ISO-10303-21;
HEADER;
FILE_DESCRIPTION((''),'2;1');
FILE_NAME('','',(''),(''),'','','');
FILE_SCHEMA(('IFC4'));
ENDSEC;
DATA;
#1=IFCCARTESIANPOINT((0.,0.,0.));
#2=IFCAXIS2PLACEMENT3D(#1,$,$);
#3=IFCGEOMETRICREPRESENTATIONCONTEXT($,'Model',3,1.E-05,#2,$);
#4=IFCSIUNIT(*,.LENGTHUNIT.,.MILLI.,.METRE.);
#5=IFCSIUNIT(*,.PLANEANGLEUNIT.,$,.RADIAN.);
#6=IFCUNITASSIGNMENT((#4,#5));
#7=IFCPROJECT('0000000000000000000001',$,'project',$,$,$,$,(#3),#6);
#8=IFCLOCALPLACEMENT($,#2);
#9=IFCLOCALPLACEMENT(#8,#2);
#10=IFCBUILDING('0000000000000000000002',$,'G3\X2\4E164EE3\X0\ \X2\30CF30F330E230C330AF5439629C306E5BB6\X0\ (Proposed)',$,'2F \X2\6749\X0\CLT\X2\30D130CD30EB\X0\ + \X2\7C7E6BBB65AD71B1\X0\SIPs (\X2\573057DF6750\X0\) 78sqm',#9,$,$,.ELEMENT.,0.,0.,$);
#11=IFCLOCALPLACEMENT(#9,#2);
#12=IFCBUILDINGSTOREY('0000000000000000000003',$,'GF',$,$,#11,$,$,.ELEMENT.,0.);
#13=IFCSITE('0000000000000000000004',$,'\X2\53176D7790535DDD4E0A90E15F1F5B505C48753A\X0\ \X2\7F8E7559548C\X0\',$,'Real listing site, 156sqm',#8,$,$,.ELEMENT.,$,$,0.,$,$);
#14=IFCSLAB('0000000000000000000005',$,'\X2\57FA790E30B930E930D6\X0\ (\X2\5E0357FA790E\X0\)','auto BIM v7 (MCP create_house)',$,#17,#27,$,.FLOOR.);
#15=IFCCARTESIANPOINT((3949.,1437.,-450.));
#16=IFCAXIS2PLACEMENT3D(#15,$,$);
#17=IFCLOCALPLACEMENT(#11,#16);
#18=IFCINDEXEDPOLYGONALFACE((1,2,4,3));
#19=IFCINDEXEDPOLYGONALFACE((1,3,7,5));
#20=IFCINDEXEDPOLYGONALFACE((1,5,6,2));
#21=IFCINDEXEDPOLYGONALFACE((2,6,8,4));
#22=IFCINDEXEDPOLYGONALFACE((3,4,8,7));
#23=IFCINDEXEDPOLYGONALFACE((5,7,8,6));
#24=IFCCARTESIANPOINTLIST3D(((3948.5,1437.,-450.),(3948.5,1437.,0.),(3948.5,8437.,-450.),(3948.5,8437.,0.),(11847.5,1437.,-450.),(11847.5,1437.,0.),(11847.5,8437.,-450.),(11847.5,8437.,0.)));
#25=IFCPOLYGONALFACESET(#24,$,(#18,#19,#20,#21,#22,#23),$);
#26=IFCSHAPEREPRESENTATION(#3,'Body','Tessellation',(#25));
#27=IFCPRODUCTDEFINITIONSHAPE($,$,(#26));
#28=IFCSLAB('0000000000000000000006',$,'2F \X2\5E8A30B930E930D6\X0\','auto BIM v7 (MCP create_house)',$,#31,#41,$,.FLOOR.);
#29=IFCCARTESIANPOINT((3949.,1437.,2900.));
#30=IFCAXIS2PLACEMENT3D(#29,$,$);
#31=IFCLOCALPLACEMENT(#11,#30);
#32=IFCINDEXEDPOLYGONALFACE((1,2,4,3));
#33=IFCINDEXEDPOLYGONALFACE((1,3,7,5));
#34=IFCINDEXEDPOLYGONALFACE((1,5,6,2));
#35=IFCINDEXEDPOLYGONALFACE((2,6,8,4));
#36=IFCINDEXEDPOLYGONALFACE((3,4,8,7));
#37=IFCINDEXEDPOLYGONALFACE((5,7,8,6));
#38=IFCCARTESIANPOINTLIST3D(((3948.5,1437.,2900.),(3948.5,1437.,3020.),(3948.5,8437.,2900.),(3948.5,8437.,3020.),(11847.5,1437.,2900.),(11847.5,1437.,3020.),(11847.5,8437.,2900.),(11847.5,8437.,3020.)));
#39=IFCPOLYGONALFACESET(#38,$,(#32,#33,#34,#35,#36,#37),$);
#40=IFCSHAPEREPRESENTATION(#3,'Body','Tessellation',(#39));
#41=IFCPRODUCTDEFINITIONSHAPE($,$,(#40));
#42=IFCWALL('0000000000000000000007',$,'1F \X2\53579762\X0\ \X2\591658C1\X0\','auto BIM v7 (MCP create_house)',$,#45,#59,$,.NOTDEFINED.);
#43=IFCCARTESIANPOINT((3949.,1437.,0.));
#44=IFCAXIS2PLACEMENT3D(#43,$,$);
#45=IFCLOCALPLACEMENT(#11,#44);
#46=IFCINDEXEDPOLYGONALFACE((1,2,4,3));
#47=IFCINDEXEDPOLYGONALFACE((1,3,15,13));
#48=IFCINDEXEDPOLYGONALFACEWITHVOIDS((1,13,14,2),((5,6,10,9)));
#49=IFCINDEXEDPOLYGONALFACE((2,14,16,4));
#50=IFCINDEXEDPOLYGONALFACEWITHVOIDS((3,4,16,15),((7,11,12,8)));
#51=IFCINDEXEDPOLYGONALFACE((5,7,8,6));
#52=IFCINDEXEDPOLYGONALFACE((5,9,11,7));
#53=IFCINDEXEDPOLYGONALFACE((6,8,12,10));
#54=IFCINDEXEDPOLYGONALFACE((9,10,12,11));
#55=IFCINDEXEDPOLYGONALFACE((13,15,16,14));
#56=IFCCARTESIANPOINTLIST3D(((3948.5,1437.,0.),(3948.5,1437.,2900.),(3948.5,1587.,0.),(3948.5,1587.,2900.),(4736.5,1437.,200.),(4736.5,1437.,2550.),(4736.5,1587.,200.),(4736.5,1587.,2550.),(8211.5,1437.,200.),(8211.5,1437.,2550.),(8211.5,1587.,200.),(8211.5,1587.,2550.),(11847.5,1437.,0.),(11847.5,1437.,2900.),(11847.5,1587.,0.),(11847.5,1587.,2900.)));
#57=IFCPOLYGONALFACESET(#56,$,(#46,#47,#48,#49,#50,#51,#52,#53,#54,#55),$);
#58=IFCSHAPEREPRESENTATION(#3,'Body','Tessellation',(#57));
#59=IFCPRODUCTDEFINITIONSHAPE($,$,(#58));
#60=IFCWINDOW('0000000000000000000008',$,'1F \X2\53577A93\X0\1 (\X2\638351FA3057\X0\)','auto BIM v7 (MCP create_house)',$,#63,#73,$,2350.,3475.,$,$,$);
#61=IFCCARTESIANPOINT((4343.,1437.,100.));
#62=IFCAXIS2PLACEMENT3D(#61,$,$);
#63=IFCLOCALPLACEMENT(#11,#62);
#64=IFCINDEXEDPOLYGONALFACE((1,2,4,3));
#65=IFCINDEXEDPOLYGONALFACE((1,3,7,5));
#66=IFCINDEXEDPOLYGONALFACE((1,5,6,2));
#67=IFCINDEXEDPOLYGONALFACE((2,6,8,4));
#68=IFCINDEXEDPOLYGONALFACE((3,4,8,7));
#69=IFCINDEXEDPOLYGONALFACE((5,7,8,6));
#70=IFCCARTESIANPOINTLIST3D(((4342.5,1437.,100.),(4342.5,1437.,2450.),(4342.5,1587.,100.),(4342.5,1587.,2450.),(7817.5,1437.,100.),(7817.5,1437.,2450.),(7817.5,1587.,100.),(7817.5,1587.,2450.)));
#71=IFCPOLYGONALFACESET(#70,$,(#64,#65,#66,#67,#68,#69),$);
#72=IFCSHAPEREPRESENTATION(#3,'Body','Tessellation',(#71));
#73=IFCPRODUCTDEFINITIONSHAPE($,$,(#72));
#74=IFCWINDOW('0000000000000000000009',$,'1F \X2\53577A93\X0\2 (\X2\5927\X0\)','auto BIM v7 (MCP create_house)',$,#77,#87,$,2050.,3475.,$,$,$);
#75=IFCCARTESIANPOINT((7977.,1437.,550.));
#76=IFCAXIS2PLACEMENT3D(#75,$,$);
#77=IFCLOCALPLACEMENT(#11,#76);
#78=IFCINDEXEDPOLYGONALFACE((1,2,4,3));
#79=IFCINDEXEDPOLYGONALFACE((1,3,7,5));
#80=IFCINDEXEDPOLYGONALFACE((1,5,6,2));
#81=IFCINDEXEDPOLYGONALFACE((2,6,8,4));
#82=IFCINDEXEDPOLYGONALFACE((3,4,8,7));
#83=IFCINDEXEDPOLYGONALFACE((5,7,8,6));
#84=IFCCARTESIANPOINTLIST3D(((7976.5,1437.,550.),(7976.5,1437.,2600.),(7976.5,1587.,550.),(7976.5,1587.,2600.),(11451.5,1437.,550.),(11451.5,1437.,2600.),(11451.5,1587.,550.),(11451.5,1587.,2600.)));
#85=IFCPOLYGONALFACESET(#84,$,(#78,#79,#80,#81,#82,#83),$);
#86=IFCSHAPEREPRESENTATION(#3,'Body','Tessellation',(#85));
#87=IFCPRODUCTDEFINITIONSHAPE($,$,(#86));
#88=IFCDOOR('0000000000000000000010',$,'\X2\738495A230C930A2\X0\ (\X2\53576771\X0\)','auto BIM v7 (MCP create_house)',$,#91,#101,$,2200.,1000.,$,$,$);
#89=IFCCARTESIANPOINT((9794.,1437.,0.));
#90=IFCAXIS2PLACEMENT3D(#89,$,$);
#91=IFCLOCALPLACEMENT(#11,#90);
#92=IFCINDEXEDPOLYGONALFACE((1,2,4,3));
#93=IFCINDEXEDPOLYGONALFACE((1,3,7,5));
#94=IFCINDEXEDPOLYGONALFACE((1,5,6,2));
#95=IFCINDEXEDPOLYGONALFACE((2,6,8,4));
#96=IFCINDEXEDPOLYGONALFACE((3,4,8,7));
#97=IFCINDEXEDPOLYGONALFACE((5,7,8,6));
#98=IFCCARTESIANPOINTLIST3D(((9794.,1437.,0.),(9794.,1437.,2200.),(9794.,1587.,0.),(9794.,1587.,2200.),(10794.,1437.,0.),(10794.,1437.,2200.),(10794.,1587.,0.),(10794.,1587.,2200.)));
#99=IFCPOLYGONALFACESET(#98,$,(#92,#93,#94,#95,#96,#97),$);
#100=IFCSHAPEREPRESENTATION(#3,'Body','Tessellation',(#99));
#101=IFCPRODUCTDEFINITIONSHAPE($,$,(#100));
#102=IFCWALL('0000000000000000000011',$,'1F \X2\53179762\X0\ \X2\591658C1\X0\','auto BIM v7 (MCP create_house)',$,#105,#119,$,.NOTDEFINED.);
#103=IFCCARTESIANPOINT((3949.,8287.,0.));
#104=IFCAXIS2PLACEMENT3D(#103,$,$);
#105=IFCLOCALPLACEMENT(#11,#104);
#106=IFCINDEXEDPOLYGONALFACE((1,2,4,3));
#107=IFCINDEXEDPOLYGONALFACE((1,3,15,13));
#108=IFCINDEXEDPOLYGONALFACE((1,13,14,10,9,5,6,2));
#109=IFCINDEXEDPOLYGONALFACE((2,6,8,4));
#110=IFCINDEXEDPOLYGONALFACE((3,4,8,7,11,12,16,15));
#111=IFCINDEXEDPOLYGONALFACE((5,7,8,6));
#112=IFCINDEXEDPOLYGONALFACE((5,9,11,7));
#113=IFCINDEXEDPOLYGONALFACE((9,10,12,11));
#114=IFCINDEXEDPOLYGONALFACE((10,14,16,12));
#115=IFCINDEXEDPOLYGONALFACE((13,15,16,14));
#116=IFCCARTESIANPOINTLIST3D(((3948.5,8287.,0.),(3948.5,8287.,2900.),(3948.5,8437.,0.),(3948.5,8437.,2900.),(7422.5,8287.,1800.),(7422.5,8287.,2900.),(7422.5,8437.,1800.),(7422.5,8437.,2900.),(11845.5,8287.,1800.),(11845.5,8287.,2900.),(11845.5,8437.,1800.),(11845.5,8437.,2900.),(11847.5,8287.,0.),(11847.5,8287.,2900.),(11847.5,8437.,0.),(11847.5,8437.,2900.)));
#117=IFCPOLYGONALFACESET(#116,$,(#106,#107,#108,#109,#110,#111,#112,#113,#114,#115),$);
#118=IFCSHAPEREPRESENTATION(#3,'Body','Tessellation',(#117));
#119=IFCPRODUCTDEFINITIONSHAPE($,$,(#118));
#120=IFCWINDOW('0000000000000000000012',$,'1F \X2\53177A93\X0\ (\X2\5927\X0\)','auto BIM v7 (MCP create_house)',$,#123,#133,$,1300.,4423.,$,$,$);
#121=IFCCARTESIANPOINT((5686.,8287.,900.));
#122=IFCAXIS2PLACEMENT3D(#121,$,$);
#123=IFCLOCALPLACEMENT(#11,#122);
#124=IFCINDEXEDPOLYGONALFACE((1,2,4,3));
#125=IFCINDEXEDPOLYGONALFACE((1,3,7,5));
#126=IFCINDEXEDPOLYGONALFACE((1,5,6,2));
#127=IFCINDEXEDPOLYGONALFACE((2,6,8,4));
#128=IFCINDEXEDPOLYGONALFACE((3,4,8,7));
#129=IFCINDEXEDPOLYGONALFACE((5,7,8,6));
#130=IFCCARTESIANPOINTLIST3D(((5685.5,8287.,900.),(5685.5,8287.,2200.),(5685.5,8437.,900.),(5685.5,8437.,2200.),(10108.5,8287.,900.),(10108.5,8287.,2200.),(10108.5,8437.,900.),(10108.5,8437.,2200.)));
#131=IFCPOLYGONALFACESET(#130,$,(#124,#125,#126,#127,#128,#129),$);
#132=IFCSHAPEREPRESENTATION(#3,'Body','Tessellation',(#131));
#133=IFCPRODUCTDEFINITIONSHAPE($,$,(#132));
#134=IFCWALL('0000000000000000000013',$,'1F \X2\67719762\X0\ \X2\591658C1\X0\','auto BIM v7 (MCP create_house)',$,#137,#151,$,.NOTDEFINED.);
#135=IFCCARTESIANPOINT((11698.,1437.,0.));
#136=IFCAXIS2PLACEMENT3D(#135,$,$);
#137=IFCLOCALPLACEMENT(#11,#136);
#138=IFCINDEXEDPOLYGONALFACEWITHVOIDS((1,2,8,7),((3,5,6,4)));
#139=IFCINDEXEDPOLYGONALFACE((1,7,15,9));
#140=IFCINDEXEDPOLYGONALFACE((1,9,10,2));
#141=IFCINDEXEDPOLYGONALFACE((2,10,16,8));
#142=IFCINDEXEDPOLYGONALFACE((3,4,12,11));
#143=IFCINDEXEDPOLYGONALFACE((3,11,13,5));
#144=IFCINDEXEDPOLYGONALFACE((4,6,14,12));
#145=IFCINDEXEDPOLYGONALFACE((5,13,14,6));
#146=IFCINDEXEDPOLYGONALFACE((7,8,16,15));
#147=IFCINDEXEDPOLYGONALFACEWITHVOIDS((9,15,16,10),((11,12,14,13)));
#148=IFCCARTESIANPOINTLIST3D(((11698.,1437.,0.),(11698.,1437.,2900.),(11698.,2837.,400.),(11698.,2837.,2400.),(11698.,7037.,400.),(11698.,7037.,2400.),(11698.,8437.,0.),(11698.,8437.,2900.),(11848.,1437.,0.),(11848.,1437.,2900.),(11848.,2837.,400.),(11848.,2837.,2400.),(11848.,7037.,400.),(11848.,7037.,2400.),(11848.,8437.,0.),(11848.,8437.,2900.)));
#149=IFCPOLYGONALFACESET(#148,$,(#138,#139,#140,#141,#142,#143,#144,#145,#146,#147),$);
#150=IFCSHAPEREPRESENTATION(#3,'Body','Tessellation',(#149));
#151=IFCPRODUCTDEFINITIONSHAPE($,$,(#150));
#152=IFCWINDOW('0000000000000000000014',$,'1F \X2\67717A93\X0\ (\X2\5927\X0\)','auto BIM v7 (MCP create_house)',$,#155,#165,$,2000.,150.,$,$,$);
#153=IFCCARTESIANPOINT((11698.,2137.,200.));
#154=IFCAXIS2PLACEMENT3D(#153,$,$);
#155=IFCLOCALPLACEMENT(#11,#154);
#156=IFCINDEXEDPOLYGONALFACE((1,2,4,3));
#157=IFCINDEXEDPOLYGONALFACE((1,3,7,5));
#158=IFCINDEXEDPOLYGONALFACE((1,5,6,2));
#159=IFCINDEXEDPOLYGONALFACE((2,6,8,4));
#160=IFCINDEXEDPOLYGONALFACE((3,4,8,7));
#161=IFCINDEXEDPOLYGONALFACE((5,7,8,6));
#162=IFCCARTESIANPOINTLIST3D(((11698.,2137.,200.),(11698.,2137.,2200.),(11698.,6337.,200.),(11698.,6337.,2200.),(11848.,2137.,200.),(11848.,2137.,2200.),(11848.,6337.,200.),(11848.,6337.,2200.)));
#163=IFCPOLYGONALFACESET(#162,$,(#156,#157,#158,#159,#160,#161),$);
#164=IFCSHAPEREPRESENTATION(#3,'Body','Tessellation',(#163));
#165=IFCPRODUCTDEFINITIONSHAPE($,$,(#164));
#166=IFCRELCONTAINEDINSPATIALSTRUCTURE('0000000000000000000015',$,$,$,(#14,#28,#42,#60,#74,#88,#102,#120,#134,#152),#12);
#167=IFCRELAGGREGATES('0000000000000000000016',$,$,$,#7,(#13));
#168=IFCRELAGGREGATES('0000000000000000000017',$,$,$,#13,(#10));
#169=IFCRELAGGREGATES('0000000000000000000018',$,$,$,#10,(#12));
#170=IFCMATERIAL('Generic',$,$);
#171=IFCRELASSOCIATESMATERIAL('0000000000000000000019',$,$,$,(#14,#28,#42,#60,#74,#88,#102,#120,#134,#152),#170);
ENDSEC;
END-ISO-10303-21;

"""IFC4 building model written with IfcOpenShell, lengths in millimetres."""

from ifc_helpers import new_model, si_unit, frame, frame_2d, origin, place, context, project, spatial, rectangle, extrude, material, element, fill, save


model = new_model("IFC4")

# Units and contexts
model_context = context("Model", 3, precision=1e-05, world=origin())
ifc_project = project(units=[si_unit("LENGTHUNIT", "METRE", prefix="MILLI"), si_unit("PLANEANGLEUNIT", "RADIAN")], contexts=[model_context])

# Site, building, storey
site_placement = place(None, origin())
site = spatial("IfcSite", under=ifc_project, at=site_placement, Name="北海道川上郡弟子屈町 美留和", ObjectType="Real listing site, 156sqm", CompositionType="ELEMENT", RefElevation=0.0)
building_placement = place(site_placement, origin())
building = spatial("IfcBuilding", under=site, at=building_placement, Name="G3世代 ハンモック吹抜の家 (Proposed)", ObjectType="2F 杉CLTパネル + 籾殻断熱SIPs (地域材) 78sqm", CompositionType="ELEMENT", ElevationOfRefHeight=0.0, ElevationOfTerrain=0.0)
storey_placement = place(building_placement, origin())
storey = spatial("IfcBuildingStorey", under=building, at=storey_placement, Name="GF", CompositionType="ELEMENT", Elevation=0.0)

# Slabs
ifc_material = material(Name="Generic")
slab_1_placement = place(storey_placement, frame((3949.0, 1437.0, -450.0)))
element("IfcSlab", 1, at=slab_1_placement, inside=storey, material=ifc_material, Name="基礎スラブ (布基礎)", Description="auto BIM v7 (MCP create_house)", PredefinedType="FLOOR", context=model_context, shape_type="SweptSolid", body=[
    extrude(rectangle(XDim=7899.0, YDim=7000.0, at=frame_2d((3949.0, 3500.0))), frame((3949.0, 1437.0, -450.0)), (0.0, 0.0, 1.0), 450.0),
])
slab_2_placement = place(storey_placement, frame((3949.0, 1437.0, 2900.0)))
element("IfcSlab", 2, at=slab_2_placement, inside=storey, material=ifc_material, Name="2F 床スラブ", Description="auto BIM v7 (MCP create_house)", PredefinedType="FLOOR", context=model_context, shape_type="SweptSolid", body=[
    extrude(rectangle(XDim=7899.0, YDim=7000.0, at=frame_2d((3949.0, 3500.0))), frame((3949.0, 1437.0, 2900.0)), (0.0, 0.0, 1.0), 120.0),
])

# Wall, openings, windows, door
wall_1_placement = place(storey_placement, frame((3949.0, 1437.0, 0.0)))
wall_1 = element("IfcWall", 3, at=wall_1_placement, inside=storey, material=ifc_material, Name="1F 南面 外壁", Description="auto BIM v7 (MCP create_house)", PredefinedType="NOTDEFINED", context=model_context, shape_type="SweptSolid", body=[
    extrude(rectangle(XDim=7899.0, YDim=150.0, at=frame_2d((3949.0, 75.0))), frame((3949.0, 1437.0, 0.0)), (0.0, 0.0, 1.0), 2900.0),
])
opening_1_placement = place(storey_placement, frame((4343.0, 1437.0, 100.0)))
opening_1 = element("IfcOpeningElement", 4, at=opening_1_placement, cuts=wall_1, PredefinedType="NOTDEFINED", context=model_context, shape_type="SweptSolid", body=[
    extrude(rectangle(XDim=3475.0, YDim=150.0, at=frame_2d((1737.0, 75.0))), frame((4343.0, 1437.0, 100.0)), (0.0, 0.0, 1.0), 2350.0),
])
opening_2_placement = place(storey_placement, frame((7977.0, 1437.0, 550.0)))
opening_2 = element("IfcOpeningElement", 5, at=opening_2_placement, cuts=wall_1, PredefinedType="NOTDEFINED", context=model_context, shape_type="SweptSolid", body=[
    extrude(rectangle(XDim=3475.0, YDim=150.0, at=frame_2d((1737.0, 75.0))), frame((7977.0, 1437.0, 550.0)), (0.0, 0.0, 1.0), 2050.0),
])
opening_3_placement = place(storey_placement, frame((9794.0, 1437.0, 0.0)))
opening_3 = element("IfcOpeningElement", 6, at=opening_3_placement, cuts=wall_1, PredefinedType="NOTDEFINED", context=model_context, shape_type="SweptSolid", body=[
    extrude(rectangle(XDim=1000.0, YDim=150.0, at=frame_2d((500.0, 75.0))), frame((9794.0, 1437.0, 0.0)), (0.0, 0.0, 1.0), 2200.0),
])
window_1_placement = place(storey_placement, frame((4343.0, 1437.0, 100.0)))
window_1 = element("IfcWindow", 7, at=window_1_placement, inside=storey, material=ifc_material, Name="1F 南窓1 (掃出し)", Description="auto BIM v7 (MCP create_house)", OverallHeight=2350.0, OverallWidth=3475.0, context=model_context, shape_type="SweptSolid", body=[
    extrude(rectangle(XDim=3475.0, YDim=150.0, at=frame_2d((1737.0, 75.0))), frame((4343.0, 1437.0, 100.0)), (0.0, 0.0, 1.0), 2350.0),
])
fill(opening_1, window_1)
window_2_placement = place(storey_placement, frame((7977.0, 1437.0, 550.0)))
window_2 = element("IfcWindow", 8, at=window_2_placement, inside=storey, material=ifc_material, Name="1F 南窓2 (大)", Description="auto BIM v7 (MCP create_house)", OverallHeight=2050.0, OverallWidth=3475.0, context=model_context, shape_type="SweptSolid", body=[
    extrude(rectangle(XDim=3475.0, YDim=150.0, at=frame_2d((1737.0, 75.0))), frame((7977.0, 1437.0, 550.0)), (0.0, 0.0, 1.0), 2050.0),
])
fill(opening_2, window_2)
door_placement = place(storey_placement, frame((9794.0, 1437.0, 0.0)))
door = element("IfcDoor", 9, at=door_placement, inside=storey, material=ifc_material, Name="玄関ドア (南東)", Description="auto BIM v7 (MCP create_house)", OverallHeight=2200.0, OverallWidth=1000.0, context=model_context, shape_type="SweptSolid", body=[
    extrude(rectangle(XDim=1000.0, YDim=150.0, at=frame_2d((500.0, 75.0))), frame((9794.0, 1437.0, 0.0)), (0.0, 0.0, 1.0), 2200.0),
])
fill(opening_3, door)

# Walls, openings, windows
wall_2_placement = place(storey_placement, frame((3949.0, 8287.0, 0.0)))
wall_2 = element("IfcWall", 10, at=wall_2_placement, inside=storey, material=ifc_material, Name="1F 北面 外壁", Description="auto BIM v7 (MCP create_house)", PredefinedType="NOTDEFINED", context=model_context, shape_type="SweptSolid", body=[
    extrude(rectangle(XDim=7899.0, YDim=150.0, at=frame_2d((3949.0, 75.0))), frame((3949.0, 8287.0, 0.0)), (0.0, 0.0, 1.0), 2900.0),
])
opening_4_placement = place(storey_placement, frame((5686.0, 8287.0, 900.0)))
opening_4 = element("IfcOpeningElement", 11, at=opening_4_placement, cuts=wall_2, PredefinedType="NOTDEFINED", context=model_context, shape_type="SweptSolid", body=[
    extrude(rectangle(XDim=4423.0, YDim=150.0, at=frame_2d((2211.0, 75.0))), frame((5686.0, 8287.0, 900.0)), (0.0, 0.0, 1.0), 1300.0),
])
window_3_placement = place(storey_placement, frame((5686.0, 8287.0, 900.0)))
window_3 = element("IfcWindow", 12, at=window_3_placement, inside=storey, material=ifc_material, Name="1F 北窓 (大)", Description="auto BIM v7 (MCP create_house)", OverallHeight=1300.0, OverallWidth=4423.0, context=model_context, shape_type="SweptSolid", body=[
    extrude(rectangle(XDim=4423.0, YDim=150.0, at=frame_2d((2211.0, 75.0))), frame((5686.0, 8287.0, 900.0)), (0.0, 0.0, 1.0), 1300.0),
])
fill(opening_4, window_3)
wall_3_placement = place(storey_placement, frame((11698.0, 1437.0, 0.0)))
wall_3 = element("IfcWall", 13, at=wall_3_placement, inside=storey, material=ifc_material, Name="1F 東面 外壁", Description="auto BIM v7 (MCP create_house)", PredefinedType="NOTDEFINED", context=model_context, shape_type="SweptSolid", body=[
    extrude(rectangle(XDim=150.0, YDim=7000.0, at=frame_2d((75.0, 3500.0))), frame((11698.0, 1437.0, 0.0)), (0.0, 0.0, 1.0), 2900.0),
])
opening_5_placement = place(storey_placement, frame((11698.0, 2137.0, 200.0)))
opening_5 = element("IfcOpeningElement", 14, at=opening_5_placement, cuts=wall_3, PredefinedType="NOTDEFINED", context=model_context, shape_type="SweptSolid", body=[
    extrude(rectangle(XDim=150.0, YDim=4200.0, at=frame_2d((75.0, 2100.0))), frame((11698.0, 2137.0, 200.0)), (0.0, 0.0, 1.0), 2000.0),
])
window_4_placement = place(storey_placement, frame((11698.0, 2137.0, 200.0)))
window_4 = element("IfcWindow", 15, at=window_4_placement, inside=storey, material=ifc_material, Name="1F 東窓 (大)", Description="auto BIM v7 (MCP create_house)", OverallHeight=2000.0, OverallWidth=150.0, context=model_context, shape_type="SweptSolid", body=[
    extrude(rectangle(XDim=150.0, YDim=4200.0, at=frame_2d((75.0, 2100.0))), frame((11698.0, 2137.0, 200.0)), (0.0, 0.0, 1.0), 2000.0),
])
fill(opening_5, window_4)

save(model, "model.ifc")
